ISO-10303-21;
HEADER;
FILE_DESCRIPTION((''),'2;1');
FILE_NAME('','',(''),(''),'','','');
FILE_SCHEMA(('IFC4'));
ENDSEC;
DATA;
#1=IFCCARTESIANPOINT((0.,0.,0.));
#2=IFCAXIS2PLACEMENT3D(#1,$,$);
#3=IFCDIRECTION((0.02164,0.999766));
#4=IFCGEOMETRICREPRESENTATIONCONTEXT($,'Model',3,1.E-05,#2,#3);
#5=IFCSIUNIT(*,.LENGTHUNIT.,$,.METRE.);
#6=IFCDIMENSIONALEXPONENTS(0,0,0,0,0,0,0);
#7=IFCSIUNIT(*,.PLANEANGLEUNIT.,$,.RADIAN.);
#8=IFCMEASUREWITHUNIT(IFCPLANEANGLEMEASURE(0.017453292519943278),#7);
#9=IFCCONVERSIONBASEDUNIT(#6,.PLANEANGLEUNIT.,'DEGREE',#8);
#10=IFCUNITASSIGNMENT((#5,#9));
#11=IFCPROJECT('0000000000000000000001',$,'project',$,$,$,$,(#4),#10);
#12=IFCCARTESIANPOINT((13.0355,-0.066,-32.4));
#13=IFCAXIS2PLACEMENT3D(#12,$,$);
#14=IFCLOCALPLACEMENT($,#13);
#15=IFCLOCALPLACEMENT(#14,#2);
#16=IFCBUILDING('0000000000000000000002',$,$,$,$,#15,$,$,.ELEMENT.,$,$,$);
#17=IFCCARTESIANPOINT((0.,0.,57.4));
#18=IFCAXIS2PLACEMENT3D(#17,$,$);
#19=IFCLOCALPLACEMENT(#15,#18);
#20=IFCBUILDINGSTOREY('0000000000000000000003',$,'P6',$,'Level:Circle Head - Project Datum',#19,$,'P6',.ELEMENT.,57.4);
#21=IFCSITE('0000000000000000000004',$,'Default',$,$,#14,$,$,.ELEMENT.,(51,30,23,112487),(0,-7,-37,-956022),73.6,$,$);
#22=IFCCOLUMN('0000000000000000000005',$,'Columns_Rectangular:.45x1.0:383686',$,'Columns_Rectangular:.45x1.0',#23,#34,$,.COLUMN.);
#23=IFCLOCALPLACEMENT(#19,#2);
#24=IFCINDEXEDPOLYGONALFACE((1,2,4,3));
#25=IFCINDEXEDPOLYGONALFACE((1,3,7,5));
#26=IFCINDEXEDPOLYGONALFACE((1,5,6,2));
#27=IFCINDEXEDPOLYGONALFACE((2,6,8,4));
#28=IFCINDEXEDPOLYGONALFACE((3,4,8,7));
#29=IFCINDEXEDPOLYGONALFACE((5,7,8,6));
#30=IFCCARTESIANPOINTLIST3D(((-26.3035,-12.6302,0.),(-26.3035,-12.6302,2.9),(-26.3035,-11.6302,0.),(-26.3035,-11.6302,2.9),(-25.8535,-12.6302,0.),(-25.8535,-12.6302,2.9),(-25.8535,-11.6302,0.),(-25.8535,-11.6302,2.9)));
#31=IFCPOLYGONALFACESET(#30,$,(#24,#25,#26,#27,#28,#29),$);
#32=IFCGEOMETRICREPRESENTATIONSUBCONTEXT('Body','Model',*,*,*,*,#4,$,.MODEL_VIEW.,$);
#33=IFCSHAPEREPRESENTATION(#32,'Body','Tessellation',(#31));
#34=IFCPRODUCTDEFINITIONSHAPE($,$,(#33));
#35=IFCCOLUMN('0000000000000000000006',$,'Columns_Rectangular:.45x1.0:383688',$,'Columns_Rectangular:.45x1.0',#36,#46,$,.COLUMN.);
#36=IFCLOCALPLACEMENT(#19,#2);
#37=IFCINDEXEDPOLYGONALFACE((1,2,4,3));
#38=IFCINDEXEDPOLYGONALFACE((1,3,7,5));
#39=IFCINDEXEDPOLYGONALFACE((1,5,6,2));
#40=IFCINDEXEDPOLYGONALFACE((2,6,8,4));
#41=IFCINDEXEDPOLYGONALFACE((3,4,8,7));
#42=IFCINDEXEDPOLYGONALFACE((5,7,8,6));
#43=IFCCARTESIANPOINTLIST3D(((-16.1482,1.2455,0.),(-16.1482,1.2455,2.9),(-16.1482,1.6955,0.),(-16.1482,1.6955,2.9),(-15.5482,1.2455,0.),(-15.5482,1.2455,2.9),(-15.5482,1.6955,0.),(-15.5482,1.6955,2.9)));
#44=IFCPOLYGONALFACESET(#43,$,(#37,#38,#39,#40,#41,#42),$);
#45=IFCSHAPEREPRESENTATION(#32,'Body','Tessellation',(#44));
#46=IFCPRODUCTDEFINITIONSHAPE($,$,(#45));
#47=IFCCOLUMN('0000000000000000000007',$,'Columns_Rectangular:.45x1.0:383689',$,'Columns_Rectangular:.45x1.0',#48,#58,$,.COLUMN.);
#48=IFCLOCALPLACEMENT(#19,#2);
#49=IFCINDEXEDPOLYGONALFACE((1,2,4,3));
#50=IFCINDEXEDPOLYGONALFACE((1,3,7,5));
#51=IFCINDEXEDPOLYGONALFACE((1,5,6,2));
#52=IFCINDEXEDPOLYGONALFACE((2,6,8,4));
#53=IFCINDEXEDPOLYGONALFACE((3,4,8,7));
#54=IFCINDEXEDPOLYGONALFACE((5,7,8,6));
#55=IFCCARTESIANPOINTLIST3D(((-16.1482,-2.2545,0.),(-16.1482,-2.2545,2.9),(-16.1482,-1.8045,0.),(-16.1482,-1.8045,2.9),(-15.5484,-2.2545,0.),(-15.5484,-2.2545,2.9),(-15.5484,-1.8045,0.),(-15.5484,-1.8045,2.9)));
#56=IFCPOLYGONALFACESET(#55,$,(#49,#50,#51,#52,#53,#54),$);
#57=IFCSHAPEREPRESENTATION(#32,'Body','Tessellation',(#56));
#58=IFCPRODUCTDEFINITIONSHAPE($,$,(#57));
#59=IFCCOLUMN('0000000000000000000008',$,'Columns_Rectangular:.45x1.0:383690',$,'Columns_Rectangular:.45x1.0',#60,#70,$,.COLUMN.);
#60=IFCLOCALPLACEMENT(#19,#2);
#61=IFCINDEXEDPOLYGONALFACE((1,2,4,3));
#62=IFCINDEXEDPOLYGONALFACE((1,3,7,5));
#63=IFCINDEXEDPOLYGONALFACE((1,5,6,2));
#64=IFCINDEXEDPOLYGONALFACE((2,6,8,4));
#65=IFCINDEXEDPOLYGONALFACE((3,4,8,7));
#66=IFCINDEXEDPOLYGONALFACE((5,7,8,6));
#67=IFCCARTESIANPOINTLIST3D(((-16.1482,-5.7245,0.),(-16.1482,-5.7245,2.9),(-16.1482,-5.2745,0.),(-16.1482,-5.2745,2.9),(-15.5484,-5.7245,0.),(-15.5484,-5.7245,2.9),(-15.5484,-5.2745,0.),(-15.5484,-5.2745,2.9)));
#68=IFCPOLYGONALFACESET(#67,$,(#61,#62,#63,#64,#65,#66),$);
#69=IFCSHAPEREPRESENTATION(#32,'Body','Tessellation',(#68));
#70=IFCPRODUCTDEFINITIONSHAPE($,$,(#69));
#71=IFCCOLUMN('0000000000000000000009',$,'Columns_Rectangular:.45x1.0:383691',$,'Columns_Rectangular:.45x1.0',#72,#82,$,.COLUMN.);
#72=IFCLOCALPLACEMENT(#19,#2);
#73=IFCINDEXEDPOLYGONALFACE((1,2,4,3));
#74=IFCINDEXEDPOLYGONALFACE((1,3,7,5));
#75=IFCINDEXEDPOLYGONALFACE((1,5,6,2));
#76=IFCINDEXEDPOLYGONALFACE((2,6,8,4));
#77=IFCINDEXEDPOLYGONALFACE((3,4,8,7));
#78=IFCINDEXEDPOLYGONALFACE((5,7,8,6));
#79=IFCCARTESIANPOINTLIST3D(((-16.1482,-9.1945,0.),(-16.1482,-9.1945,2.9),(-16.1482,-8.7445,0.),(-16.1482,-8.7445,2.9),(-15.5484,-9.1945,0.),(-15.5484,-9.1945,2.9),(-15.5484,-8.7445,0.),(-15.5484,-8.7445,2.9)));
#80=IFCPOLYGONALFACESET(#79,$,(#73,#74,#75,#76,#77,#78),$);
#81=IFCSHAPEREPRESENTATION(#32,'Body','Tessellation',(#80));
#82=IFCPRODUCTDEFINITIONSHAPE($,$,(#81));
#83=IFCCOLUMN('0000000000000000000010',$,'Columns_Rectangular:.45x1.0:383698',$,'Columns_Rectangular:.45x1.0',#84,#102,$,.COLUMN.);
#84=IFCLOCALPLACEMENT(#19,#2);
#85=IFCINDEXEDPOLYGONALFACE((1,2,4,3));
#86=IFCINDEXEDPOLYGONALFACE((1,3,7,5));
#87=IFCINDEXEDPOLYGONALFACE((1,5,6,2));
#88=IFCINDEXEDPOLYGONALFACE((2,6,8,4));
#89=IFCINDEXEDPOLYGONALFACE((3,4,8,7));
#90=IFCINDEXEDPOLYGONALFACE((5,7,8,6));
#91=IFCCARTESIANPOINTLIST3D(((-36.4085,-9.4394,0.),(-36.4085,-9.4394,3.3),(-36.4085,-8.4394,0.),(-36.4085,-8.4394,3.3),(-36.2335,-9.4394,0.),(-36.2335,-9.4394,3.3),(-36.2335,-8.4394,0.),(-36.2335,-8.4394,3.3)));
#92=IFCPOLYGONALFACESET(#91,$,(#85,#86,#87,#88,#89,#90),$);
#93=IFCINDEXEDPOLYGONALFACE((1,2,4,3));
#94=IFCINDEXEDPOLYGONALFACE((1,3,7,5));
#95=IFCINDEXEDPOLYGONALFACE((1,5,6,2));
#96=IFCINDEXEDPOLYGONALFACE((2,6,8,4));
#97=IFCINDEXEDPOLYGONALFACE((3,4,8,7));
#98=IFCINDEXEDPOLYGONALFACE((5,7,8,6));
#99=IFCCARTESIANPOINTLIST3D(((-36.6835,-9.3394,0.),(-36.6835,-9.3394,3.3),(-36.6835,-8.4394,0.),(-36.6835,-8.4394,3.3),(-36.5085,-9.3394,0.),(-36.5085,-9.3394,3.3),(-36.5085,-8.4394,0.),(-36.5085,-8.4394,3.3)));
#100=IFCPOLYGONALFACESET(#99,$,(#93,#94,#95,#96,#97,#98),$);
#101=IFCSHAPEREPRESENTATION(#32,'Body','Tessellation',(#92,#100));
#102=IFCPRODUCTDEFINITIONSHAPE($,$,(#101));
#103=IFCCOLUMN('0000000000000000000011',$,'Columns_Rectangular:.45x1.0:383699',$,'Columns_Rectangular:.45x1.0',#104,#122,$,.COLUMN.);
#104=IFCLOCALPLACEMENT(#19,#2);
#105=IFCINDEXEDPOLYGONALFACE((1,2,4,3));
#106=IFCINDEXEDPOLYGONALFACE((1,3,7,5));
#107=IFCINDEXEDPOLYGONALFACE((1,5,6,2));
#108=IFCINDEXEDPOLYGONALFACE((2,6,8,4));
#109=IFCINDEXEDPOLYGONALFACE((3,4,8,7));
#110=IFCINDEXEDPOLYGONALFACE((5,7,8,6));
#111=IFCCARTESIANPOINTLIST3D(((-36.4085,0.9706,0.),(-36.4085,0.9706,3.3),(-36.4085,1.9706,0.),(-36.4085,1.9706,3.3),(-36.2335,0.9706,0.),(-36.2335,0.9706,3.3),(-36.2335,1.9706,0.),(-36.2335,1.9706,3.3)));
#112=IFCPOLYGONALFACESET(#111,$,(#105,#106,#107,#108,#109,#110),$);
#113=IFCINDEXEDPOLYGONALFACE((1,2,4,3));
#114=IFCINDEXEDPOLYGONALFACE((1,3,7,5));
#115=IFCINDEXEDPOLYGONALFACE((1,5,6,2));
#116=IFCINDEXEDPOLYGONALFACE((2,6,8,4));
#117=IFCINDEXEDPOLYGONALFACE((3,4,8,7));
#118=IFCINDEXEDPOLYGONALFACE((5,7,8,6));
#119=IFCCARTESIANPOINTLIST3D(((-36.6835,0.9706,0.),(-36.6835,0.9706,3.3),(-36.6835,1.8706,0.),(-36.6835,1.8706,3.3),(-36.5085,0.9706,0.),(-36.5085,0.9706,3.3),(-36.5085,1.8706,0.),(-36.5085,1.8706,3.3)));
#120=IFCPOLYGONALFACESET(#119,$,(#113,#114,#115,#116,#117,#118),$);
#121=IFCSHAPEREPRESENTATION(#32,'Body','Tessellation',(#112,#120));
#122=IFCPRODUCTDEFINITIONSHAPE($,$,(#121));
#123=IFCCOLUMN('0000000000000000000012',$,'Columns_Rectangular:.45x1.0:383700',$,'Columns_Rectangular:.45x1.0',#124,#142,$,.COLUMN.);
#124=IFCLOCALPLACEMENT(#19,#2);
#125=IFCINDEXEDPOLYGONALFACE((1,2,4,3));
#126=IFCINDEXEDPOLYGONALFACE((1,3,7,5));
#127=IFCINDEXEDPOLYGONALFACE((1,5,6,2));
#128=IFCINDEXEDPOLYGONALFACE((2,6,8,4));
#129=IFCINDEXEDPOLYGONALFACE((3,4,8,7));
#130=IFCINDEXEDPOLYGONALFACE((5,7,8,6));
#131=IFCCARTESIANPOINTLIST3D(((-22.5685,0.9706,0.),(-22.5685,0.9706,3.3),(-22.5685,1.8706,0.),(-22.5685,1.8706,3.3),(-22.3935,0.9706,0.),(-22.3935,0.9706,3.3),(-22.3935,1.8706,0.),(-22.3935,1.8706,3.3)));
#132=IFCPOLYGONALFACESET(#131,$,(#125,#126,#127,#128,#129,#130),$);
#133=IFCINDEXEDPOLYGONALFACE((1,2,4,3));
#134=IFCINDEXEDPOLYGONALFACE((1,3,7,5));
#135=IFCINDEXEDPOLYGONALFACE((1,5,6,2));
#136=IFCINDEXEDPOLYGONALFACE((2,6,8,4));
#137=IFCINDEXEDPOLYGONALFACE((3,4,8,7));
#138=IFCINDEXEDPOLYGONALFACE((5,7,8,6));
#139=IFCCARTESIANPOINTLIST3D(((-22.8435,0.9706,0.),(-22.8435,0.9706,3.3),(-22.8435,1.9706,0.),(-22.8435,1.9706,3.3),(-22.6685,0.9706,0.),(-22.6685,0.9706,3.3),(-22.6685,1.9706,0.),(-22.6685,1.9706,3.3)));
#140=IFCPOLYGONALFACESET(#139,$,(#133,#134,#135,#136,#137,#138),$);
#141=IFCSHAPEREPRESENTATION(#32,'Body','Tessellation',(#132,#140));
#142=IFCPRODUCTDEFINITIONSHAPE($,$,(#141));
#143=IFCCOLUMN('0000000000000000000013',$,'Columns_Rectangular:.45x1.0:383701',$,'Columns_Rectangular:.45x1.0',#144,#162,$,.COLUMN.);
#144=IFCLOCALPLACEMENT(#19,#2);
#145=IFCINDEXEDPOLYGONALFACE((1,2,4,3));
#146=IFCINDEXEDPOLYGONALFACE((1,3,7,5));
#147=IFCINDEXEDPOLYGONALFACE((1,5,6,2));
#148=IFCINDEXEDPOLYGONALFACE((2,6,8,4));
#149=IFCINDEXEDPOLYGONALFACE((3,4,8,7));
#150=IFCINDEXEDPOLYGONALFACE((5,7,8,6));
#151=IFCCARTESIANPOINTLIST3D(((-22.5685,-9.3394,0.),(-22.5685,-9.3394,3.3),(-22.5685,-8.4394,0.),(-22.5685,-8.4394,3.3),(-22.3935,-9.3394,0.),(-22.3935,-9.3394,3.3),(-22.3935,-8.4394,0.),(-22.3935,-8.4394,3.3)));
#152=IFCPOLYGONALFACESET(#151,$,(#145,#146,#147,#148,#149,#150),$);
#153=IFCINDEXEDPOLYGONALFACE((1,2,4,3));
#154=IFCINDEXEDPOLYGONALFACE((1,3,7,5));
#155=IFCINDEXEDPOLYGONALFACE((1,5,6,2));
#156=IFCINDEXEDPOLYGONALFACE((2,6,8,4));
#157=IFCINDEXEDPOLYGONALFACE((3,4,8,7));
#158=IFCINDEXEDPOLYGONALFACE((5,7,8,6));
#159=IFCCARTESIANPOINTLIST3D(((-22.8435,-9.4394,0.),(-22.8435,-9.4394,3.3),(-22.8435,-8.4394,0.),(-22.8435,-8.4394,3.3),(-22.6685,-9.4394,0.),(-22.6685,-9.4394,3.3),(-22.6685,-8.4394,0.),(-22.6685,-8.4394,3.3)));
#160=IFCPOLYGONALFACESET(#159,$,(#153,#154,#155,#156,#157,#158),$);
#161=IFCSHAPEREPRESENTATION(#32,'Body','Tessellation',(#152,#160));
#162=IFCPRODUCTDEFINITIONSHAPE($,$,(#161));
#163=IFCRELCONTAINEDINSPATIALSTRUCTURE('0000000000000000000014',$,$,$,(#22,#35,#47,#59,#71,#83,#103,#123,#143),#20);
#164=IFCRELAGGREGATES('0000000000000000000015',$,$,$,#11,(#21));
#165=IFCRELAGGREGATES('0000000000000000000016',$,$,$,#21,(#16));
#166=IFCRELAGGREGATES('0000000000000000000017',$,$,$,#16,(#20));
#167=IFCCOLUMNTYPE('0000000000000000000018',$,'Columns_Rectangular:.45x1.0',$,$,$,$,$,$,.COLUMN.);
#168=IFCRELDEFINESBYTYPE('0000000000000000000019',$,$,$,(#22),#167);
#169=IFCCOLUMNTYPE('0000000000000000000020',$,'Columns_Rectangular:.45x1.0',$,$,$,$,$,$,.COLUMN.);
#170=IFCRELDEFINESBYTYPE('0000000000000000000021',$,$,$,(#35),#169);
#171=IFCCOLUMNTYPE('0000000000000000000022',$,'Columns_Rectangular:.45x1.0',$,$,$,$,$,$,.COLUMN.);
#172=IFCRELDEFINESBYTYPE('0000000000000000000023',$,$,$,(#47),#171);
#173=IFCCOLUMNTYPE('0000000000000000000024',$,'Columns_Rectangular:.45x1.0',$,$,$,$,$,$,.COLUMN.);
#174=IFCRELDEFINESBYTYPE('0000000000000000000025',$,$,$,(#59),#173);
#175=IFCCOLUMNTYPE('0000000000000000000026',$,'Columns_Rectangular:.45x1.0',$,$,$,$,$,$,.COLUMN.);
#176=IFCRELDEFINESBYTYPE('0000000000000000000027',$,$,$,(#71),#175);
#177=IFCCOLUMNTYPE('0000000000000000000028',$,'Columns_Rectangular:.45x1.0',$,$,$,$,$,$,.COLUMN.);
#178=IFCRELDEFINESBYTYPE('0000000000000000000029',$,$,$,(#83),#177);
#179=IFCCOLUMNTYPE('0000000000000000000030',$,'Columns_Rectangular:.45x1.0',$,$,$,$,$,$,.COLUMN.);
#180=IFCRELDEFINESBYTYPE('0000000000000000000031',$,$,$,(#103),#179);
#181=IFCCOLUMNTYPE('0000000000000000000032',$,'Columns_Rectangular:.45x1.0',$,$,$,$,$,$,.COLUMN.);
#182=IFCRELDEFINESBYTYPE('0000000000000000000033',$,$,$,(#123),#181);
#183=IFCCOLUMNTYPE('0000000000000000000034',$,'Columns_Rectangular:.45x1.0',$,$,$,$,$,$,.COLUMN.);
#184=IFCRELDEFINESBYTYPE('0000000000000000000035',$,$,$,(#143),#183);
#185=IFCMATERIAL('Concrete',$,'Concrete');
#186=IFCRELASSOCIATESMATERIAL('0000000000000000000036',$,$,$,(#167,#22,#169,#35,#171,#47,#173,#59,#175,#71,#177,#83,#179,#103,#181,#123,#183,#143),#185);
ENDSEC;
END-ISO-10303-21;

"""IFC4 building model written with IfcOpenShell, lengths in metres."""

from ifc_helpers import new_model, entity, si_unit, converted_unit, direction, frame, origin, place, context, subcontext, project, spatial, indexed_curve, outline, extrude, source, transform, mapped, material, type_object, type_shapes, element, save


model = new_model("IFC4")

# Units and contexts
model_context = context("Model", 3, precision=1e-05, world=origin(), true_north=direction((0.02164, 0.999766)))
body_context = subcontext(model_context, "Body", "Model", "MODEL_VIEW")
ifc_project = project(units=[si_unit("LENGTHUNIT", "METRE"), converted_unit("PLANEANGLEUNIT", "DEGREE", entity("IfcPlaneAngleMeasure", 0.017453292519943278), si_unit("PLANEANGLEUNIT", "RADIAN"), dimensions=[0, 0, 0, 0, 0, 0, 0])], contexts=[model_context])

# Site, building, storey
site_placement = place(None, frame((13.0355, -0.066, -32.4)))
site = spatial("IfcSite", under=ifc_project, at=site_placement, Name="Default", CompositionType="ELEMENT", RefLatitude=(51, 30, 23, 112487), RefLongitude=(0, -7, -37, -956022), RefElevation=73.6)
building_placement = place(site_placement, origin())
building = spatial("IfcBuilding", under=site, at=building_placement, CompositionType="ELEMENT")
storey_placement = place(building_placement, frame((0.0, 0.0, 57.4)))
storey = spatial("IfcBuildingStorey", under=building, at=storey_placement, Name="P6", ObjectType="Level:Circle Head - Project Datum", LongName="P6", CompositionType="ELEMENT", Elevation=57.4)

# Columns
ifc_material = material(Name="Concrete", Category="Concrete")
column_type_1 = type_object("IfcColumnType", Name="Columns_Rectangular:.45x1.0", PredefinedType="COLUMN", material=ifc_material)
shared_shape_1 = source(origin(), body_context, "Body", "SweptSolid", [
    extrude(outline(indexed_curve([(-0.5, -0.225), (0.5, -0.225), (0.5, 0.225), (-0.5, 0.225), (-0.5, -0.225)], self_intersect=False)), frame((-26.0785, -12.1302, 57.4), z_axis=(0.0, 0.0, 1.0), x_axis=(0.000011, 1.0, 0.0)), (0.0, 0.0, 1.0), 2.9),
])
type_shapes(column_type_1, [shared_shape_1])
column_1_placement = place(storey_placement, frame((0.0, 0.0, -57.4)))
element("IfcColumn", 1, at=column_1_placement, inside=storey, type_object=column_type_1, material=ifc_material, Name="Columns_Rectangular:.45x1.0:383686", ObjectType="Columns_Rectangular:.45x1.0", PredefinedType="COLUMN", context=body_context, shape_type="MappedRepresentation", body=[
    mapped(shared_shape_1, transform((0.0, 0.0, 0.0), scale=1.0)),
])
column_type_2 = type_object("IfcColumnType", Name="Columns_Rectangular:.45x1.0", PredefinedType="COLUMN", material=ifc_material)
shared_shape_2 = source(origin(), body_context, "Body", "SweptSolid", [
    extrude(outline(indexed_curve([(-0.3, -0.225), (0.3, -0.225), (0.3, 0.225), (-0.3, 0.225), (-0.3, -0.225)], self_intersect=False)), frame((-15.8482, 1.4705, 57.4), z_axis=(0.0, 0.0, 1.0), x_axis=(-1.0, 0.0, 0.0)), (0.0, 0.0, 1.0), 2.9),
])
type_shapes(column_type_2, [shared_shape_2])
column_2_placement = place(storey_placement, frame((0.0, 0.0, -57.4)))
element("IfcColumn", 2, at=column_2_placement, inside=storey, type_object=column_type_2, material=ifc_material, Name="Columns_Rectangular:.45x1.0:383688", ObjectType="Columns_Rectangular:.45x1.0", PredefinedType="COLUMN", context=body_context, shape_type="MappedRepresentation", body=[
    mapped(shared_shape_2, transform((0.0, 0.0, 0.0), scale=1.0)),
])
column_type_3 = type_object("IfcColumnType", Name="Columns_Rectangular:.45x1.0", PredefinedType="COLUMN", material=ifc_material)
shared_shape_3 = source(origin(), body_context, "Body", "SweptSolid", [
    extrude(outline(indexed_curve([(-0.2999, -0.225), (0.2999, -0.225), (0.2999, 0.225), (-0.2999, 0.225), (-0.2999, -0.225)], self_intersect=False)), frame((-15.8483, -2.0295, 57.4), z_axis=(0.0, 0.0, 1.0), x_axis=(-1.0, 0.0, 0.0)), (0.0, 0.0, 1.0), 2.9),
])
type_shapes(column_type_3, [shared_shape_3])
column_3_placement = place(storey_placement, frame((0.0, 0.0, -57.4)))
element("IfcColumn", 3, at=column_3_placement, inside=storey, type_object=column_type_3, material=ifc_material, Name="Columns_Rectangular:.45x1.0:383689", ObjectType="Columns_Rectangular:.45x1.0", PredefinedType="COLUMN", context=body_context, shape_type="MappedRepresentation", body=[
    mapped(shared_shape_3, transform((0.0, 0.0, 0.0), scale=1.0)),
])
column_type_4 = type_object("IfcColumnType", Name="Columns_Rectangular:.45x1.0", PredefinedType="COLUMN", material=ifc_material)
shared_shape_4 = source(origin(), body_context, "Body", "SweptSolid", [
    extrude(outline(indexed_curve([(-0.2999, -0.225), (0.2999, -0.225), (0.2999, 0.225), (-0.2999, 0.225), (-0.2999, -0.225)], self_intersect=False)), frame((-15.8483, -5.4995, 57.4), z_axis=(0.0, 0.0, 1.0), x_axis=(-1.0, 0.0, 0.0)), (0.0, 0.0, 1.0), 2.9),
])
type_shapes(column_type_4, [shared_shape_4])
column_4_placement = place(storey_placement, frame((0.0, 0.0, -57.4)))
element("IfcColumn", 4, at=column_4_placement, inside=storey, type_object=column_type_4, material=ifc_material, Name="Columns_Rectangular:.45x1.0:383690", ObjectType="Columns_Rectangular:.45x1.0", PredefinedType="COLUMN", context=body_context, shape_type="MappedRepresentation", body=[
    mapped(shared_shape_4, transform((0.0, 0.0, 0.0), scale=1.0)),
])
column_type_5 = type_object("IfcColumnType", Name="Columns_Rectangular:.45x1.0", PredefinedType="COLUMN", material=ifc_material)
shared_shape_5 = source(origin(), body_context, "Body", "SweptSolid", [
    extrude(outline(indexed_curve([(-0.2999, -0.225), (0.2999, -0.225), (0.2999, 0.225), (-0.2999, 0.225), (-0.2999, -0.225)], self_intersect=False)), frame((-15.8483, -8.9695, 57.4), z_axis=(0.0, 0.0, 1.0), x_axis=(-1.0, 0.0, 0.0)), (0.0, 0.0, 1.0), 2.9),
])
type_shapes(column_type_5, [shared_shape_5])
column_5_placement = place(storey_placement, frame((0.0, 0.0, -57.4)))
element("IfcColumn", 5, at=column_5_placement, inside=storey, type_object=column_type_5, material=ifc_material, Name="Columns_Rectangular:.45x1.0:383691", ObjectType="Columns_Rectangular:.45x1.0", PredefinedType="COLUMN", context=body_context, shape_type="MappedRepresentation", body=[
    mapped(shared_shape_5, transform((0.0, 0.0, 0.0), scale=1.0)),
])
column_type_6 = type_object("IfcColumnType", Name="Columns_Rectangular:.45x1.0", PredefinedType="COLUMN", material=ifc_material)
shared_shape_6 = source(origin(), body_context, "Body", "SweptSolid", [
    extrude(outline(indexed_curve([(-0.0875, -0.5), (0.0875, -0.5), (0.0875, 0.5), (-0.0875, 0.5), (-0.0875, -0.5)], self_intersect=False)), frame((-36.321, -8.9394, 57.4), z_axis=(0.0, 0.0, 1.0), x_axis=(-1.0, 0.0, 0.0)), (0.0, 0.0, 1.0), 3.3),
    extrude(outline(indexed_curve([(-0.45, -0.0875), (0.45, -0.0875), (0.45, 0.0875), (-0.45, 0.0875), (-0.45, -0.0875)], self_intersect=False)), frame((-36.596, -8.8894, 57.4), z_axis=(0.0, 0.0, 1.0), x_axis=(0.0, -1.0, 0.0)), (0.0, 0.0, 1.0), 3.3),
])
type_shapes(column_type_6, [shared_shape_6])
column_6_placement = place(storey_placement, frame((0.0, 0.0, -57.4)))
element("IfcColumn", 6, at=column_6_placement, inside=storey, type_object=column_type_6, material=ifc_material, Name="Columns_Rectangular:.45x1.0:383698", ObjectType="Columns_Rectangular:.45x1.0", PredefinedType="COLUMN", context=body_context, shape_type="MappedRepresentation", body=[
    mapped(shared_shape_6, transform((0.0, 0.0, 0.0), scale=1.0)),
])
column_type_7 = type_object("IfcColumnType", Name="Columns_Rectangular:.45x1.0", PredefinedType="COLUMN", material=ifc_material)
shared_shape_7 = source(origin(), body_context, "Body", "SweptSolid", [
    extrude(outline(indexed_curve([(-0.0875, -0.5), (0.0875, -0.5), (0.0875, 0.5), (-0.0875, 0.5), (-0.0875, -0.5)], self_intersect=False)), frame((-36.321, 1.4706, 57.4), z_axis=(0.0, 0.0, 1.0), x_axis=(-1.0, 0.0, 0.0)), (0.0, 0.0, 1.0), 3.3),
    extrude(outline(indexed_curve([(-0.45, -0.0875), (0.45, -0.0875), (0.45, 0.0875), (-0.45, 0.0875), (-0.45, -0.0875)], self_intersect=False)), frame((-36.596, 1.4206, 57.4), z_axis=(0.0, 0.0, 1.0), x_axis=(0.0, 1.0, 0.0)), (0.0, 0.0, 1.0), 3.3),
])
type_shapes(column_type_7, [shared_shape_7])
column_7_placement = place(storey_placement, frame((0.0, 0.0, -57.4)))
element("IfcColumn", 7, at=column_7_placement, inside=storey, type_object=column_type_7, material=ifc_material, Name="Columns_Rectangular:.45x1.0:383699", ObjectType="Columns_Rectangular:.45x1.0", PredefinedType="COLUMN", context=body_context, shape_type="MappedRepresentation", body=[
    mapped(shared_shape_7, transform((0.0, 0.0, 0.0), scale=1.0)),
])
column_type_8 = type_object("IfcColumnType", Name="Columns_Rectangular:.45x1.0", PredefinedType="COLUMN", material=ifc_material)
shared_shape_8 = source(origin(), body_context, "Body", "SweptSolid", [
    extrude(outline(indexed_curve([(-0.45, -0.0875), (0.45, -0.0875), (0.45, 0.0875), (-0.45, 0.0875), (-0.45, -0.0875)], self_intersect=False)), frame((-22.481, 1.4206, 57.4), z_axis=(0.0, 0.0, 1.0), x_axis=(0.0, 1.0, 0.0)), (0.0, 0.0, 1.0), 3.3),
    extrude(outline(indexed_curve([(-0.0875, -0.5), (0.0875, -0.5), (0.0875, 0.5), (-0.0875, 0.5), (-0.0875, -0.5)], self_intersect=False)), frame((-22.756, 1.4706, 57.4)), (0.0, 0.0, 1.0), 3.3),
])
type_shapes(column_type_8, [shared_shape_8])
column_8_placement = place(storey_placement, frame((0.0, 0.0, -57.4)))
element("IfcColumn", 8, at=column_8_placement, inside=storey, type_object=column_type_8, material=ifc_material, Name="Columns_Rectangular:.45x1.0:383700", ObjectType="Columns_Rectangular:.45x1.0", PredefinedType="COLUMN", context=body_context, shape_type="MappedRepresentation", body=[
    mapped(shared_shape_8, transform((0.0, 0.0, 0.0), scale=1.0)),
])
column_type_9 = type_object("IfcColumnType", Name="Columns_Rectangular:.45x1.0", PredefinedType="COLUMN", material=ifc_material)
shared_shape_9 = source(origin(), body_context, "Body", "SweptSolid", [
    extrude(outline(indexed_curve([(-0.45, -0.0875), (0.45, -0.0875), (0.45, 0.0875), (-0.45, 0.0875), (-0.45, -0.0875)], self_intersect=False)), frame((-22.481, -8.8894, 57.4), z_axis=(0.0, 0.0, 1.0), x_axis=(0.0, -1.0, 0.0)), (0.0, 0.0, 1.0), 3.3),
    extrude(outline(indexed_curve([(-0.0875, -0.5), (0.0875, -0.5), (0.0875, 0.5), (-0.0875, 0.5), (-0.0875, -0.5)], self_intersect=False)), frame((-22.756, -8.9394, 57.4)), (0.0, 0.0, 1.0), 3.3),
])
type_shapes(column_type_9, [shared_shape_9])
column_9_placement = place(storey_placement, frame((0.0, 0.0, -57.4)))
element("IfcColumn", 9, at=column_9_placement, inside=storey, type_object=column_type_9, material=ifc_material, Name="Columns_Rectangular:.45x1.0:383701", ObjectType="Columns_Rectangular:.45x1.0", PredefinedType="COLUMN", context=body_context, shape_type="MappedRepresentation", body=[
    mapped(shared_shape_9, transform((0.0, 0.0, 0.0), scale=1.0)),
])

save(model, "model.ifc")
